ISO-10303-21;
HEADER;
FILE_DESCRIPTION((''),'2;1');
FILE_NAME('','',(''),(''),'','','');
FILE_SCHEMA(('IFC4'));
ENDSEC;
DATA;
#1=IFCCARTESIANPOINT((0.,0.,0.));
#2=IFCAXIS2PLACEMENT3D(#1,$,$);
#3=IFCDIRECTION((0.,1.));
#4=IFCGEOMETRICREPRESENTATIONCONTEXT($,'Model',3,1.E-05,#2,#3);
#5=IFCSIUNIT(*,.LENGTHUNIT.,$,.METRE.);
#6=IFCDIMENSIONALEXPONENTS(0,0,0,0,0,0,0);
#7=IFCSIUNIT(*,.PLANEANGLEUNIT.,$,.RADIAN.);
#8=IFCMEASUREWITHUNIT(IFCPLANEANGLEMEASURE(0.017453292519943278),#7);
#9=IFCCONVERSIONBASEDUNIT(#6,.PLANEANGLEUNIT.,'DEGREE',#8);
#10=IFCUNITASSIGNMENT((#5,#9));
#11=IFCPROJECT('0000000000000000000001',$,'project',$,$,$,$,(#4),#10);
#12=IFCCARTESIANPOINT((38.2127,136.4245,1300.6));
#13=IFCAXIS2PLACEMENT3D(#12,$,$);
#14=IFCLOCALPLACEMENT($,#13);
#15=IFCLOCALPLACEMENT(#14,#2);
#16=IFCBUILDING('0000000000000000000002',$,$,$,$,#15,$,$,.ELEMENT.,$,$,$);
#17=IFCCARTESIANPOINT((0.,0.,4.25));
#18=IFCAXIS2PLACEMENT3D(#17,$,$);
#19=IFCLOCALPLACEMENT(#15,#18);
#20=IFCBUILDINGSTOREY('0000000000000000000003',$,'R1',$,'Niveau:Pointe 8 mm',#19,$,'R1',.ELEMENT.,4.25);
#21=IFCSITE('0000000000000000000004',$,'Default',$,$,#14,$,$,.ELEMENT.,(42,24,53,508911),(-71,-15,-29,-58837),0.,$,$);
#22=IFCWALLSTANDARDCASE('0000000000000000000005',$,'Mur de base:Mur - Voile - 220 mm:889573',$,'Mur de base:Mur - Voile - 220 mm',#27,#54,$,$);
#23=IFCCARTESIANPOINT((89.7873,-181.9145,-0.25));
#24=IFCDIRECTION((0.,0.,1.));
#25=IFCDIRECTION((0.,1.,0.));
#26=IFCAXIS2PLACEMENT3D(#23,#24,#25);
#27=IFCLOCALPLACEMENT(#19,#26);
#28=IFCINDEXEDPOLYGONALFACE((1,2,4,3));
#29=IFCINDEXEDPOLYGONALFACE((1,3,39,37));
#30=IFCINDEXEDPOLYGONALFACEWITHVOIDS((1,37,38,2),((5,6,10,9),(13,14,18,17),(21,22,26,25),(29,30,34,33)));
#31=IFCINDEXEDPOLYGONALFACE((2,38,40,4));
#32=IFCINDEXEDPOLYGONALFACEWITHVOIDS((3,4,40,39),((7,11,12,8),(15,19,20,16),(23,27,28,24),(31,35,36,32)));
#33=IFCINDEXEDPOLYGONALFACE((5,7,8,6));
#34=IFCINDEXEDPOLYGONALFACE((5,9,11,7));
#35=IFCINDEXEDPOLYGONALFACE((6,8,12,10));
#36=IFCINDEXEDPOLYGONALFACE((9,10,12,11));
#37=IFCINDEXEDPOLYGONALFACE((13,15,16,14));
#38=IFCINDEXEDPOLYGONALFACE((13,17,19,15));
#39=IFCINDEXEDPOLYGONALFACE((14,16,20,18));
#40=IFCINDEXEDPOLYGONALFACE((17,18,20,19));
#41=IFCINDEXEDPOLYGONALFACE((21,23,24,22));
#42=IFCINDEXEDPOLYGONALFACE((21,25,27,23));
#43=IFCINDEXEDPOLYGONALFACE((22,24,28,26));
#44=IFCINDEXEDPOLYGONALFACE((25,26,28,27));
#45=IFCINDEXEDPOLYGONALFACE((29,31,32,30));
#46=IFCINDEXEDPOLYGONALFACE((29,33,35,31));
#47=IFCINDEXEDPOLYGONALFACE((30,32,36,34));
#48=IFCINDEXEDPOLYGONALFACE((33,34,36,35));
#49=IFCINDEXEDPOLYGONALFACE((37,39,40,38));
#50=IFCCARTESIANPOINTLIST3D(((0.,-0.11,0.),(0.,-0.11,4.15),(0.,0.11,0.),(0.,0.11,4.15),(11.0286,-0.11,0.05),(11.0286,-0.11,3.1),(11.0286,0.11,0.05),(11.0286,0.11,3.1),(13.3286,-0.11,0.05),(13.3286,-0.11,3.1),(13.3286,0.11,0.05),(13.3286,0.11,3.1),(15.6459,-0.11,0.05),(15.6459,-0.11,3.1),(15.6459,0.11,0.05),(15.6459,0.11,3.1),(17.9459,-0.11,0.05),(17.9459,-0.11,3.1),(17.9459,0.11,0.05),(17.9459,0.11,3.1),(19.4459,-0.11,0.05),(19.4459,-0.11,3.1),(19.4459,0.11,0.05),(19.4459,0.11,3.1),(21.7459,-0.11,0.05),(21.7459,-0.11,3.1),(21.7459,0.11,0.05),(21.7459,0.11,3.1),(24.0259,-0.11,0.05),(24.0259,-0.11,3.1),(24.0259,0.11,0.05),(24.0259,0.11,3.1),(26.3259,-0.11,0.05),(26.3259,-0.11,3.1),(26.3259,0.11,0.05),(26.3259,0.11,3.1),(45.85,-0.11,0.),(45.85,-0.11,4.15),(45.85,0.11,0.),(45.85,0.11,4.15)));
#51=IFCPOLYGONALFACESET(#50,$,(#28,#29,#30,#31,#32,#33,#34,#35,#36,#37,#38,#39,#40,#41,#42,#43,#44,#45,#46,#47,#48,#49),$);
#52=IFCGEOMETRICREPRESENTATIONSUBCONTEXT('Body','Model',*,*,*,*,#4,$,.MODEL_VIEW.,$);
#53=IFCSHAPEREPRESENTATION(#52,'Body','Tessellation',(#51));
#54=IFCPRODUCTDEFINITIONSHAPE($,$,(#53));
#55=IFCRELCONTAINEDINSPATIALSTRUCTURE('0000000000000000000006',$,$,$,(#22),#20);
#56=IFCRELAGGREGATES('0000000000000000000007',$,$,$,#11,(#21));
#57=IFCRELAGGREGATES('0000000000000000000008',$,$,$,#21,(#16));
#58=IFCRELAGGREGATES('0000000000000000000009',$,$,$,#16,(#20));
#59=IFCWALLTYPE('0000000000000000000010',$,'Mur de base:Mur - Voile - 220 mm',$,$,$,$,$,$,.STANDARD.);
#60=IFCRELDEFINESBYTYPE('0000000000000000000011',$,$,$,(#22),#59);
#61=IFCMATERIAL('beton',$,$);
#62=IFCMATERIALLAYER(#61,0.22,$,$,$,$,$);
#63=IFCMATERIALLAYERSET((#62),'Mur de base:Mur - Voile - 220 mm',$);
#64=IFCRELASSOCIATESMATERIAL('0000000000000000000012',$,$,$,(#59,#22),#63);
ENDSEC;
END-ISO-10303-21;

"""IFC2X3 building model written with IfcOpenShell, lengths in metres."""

from ifc_helpers import new_model, entity, si_unit, converted_unit, direction, frame, frame_2d, origin, place, context, subcontext, project, spatial, polyline, rectangle, extrude, clip, bounded_halfspace, material, layer, layer_set, layer_usage, type_object, element, save


model = new_model("IFC2X3")

# Units and contexts
model_context = context("Model", 3, precision=1e-05, world=origin(), true_north=direction((0.0, 1.0)))
body_context = subcontext(model_context, "Body", "Model", "MODEL_VIEW")
ifc_project = project(units=[si_unit("LENGTHUNIT", "METRE"), converted_unit("PLANEANGLEUNIT", "DEGREE", entity("IfcPlaneAngleMeasure", 0.017453292519943278), si_unit("PLANEANGLEUNIT", "RADIAN"), dimensions=[0, 0, 0, 0, 0, 0, 0])], contexts=[model_context])

# Site, building, storey
site_placement = place(None, frame((38.2127, 136.4245, 1300.6)))
site = spatial("IfcSite", under=ifc_project, at=site_placement, Name="Default", CompositionType="ELEMENT", RefLatitude=(42, 24, 53, 508911), RefLongitude=(-71, -15, -29, -58837), RefElevation=0.0)
building_placement = place(site_placement, origin())
building = spatial("IfcBuilding", under=site, at=building_placement, CompositionType="ELEMENT")
storey_placement = place(building_placement, frame((0.0, 0.0, 4.25)))
storey = spatial("IfcBuildingStorey", under=building, at=storey_placement, Name="R1", ObjectType="Niveau:Pointe 8 mm", LongName="R1", CompositionType="ELEMENT", Elevation=4.25)

# Wall, openings
ifc_material = material(Name="beton")
ifc_layer = layer(ifc_material, 0.22)
ifc_layer_set = layer_set([ifc_layer], Name="Mur de base:Mur - Voile - 220 mm")
ifc_layer_usage_1 = layer_usage(ifc_layer_set, "AXIS2", "NEGATIVE", 0.11)
wall_type = type_object("IfcWallType", Name="Mur de base:Mur - Voile - 220 mm", PredefinedType="STANDARD", material=ifc_layer_set)
wall_1_placement = place(storey_placement, frame((89.7873, -181.9145, -0.25), z_axis=(0.0, 0.0, 1.0), x_axis=(0.0, 1.0, 0.0)))
wall_1 = element("IfcWallStandardCase", 1, at=wall_1_placement, inside=storey, type_object=wall_type, material=ifc_layer_usage_1, Name="Mur de base:Mur - Voile - 220 mm:889573", ObjectType="Mur de base:Mur - Voile - 220 mm", context=body_context, shape_type="Clipping", body=[
    clip(clip(extrude(rectangle(XDim=45.85, YDim=0.22, at=frame_2d((22.925, 0.0), x_axis=(-1.0, 0.0))), origin(), (0.0, 0.0, 1.0), 4.15), bounded_halfspace(frame((35.415, -0.11, 4.15), z_axis=(0.0, 0.0, -1.0), x_axis=(0.0, -1.0, 0.0)), True, frame((35.415, -0.11, 4.15)), polyline([(0.0, 0.0), (10.185, 0.0), (10.185, 0.22), (4.42, 0.22), (4.2, 0.22), (0.22, 0.22), (0.0, 0.22), (0.0, 0.0)]))), bounded_halfspace(frame((0.25, -0.11, 4.15), z_axis=(0.0, 0.0, -1.0), x_axis=(0.0, -1.0, 0.0)), True, frame((0.25, -0.11, 4.15)), polyline([(0.0, 0.0), (32.765, 0.0), (32.765, 0.22), (32.545, 0.22), (31.185, 0.22), (30.965, 0.22), (27.12, 0.22), (26.9, 0.22), (8.8891, 0.22), (8.6691, 0.22), (0.0, 0.22), (0.0, 0.0)]))),
])
opening_1_placement = place(wall_1_placement, origin())
element("IfcOpeningElement", 2, at=opening_1_placement, cuts=wall_1, ObjectType="Opening", context=body_context, shape_type="SweptSolid", body=[
    extrude(rectangle(XDim=3.05, YDim=2.3, at=frame_2d((0.0, 0.0), x_axis=(0.0, 1.0))), frame((12.1786, 0.11, 1.575), z_axis=(0.0, -1.0, 0.0), x_axis=(-1.0, 0.0, 0.0)), (0.0, 0.0, 1.0), 0.22),
])
opening_2_placement = place(wall_1_placement, origin())
element("IfcOpeningElement", 3, at=opening_2_placement, cuts=wall_1, ObjectType="Opening", context=body_context, shape_type="SweptSolid", body=[
    extrude(rectangle(XDim=3.05, YDim=2.3, at=frame_2d((0.0, 0.0), x_axis=(0.0, 1.0))), frame((16.7959, 0.11, 1.575), z_axis=(0.0, -1.0, 0.0), x_axis=(-1.0, 0.0, 0.0)), (0.0, 0.0, 1.0), 0.22),
])
opening_3_placement = place(wall_1_placement, origin())
element("IfcOpeningElement", 4, at=opening_3_placement, cuts=wall_1, ObjectType="Opening", context=body_context, shape_type="SweptSolid", body=[
    extrude(rectangle(XDim=3.05, YDim=2.3, at=frame_2d((0.0, 0.0), x_axis=(0.0, 1.0))), frame((20.5959, 0.11, 1.575), z_axis=(0.0, -1.0, 0.0), x_axis=(-1.0, 0.0, 0.0)), (0.0, 0.0, 1.0), 0.22),
])
opening_4_placement = place(wall_1_placement, origin())
element("IfcOpeningElement", 5, at=opening_4_placement, cuts=wall_1, ObjectType="Opening", context=body_context, shape_type="SweptSolid", body=[
    extrude(rectangle(XDim=3.05, YDim=2.3, at=frame_2d((0.0, 0.0), x_axis=(0.0, 1.0))), frame((25.1759, 0.11, 1.575), z_axis=(0.0, -1.0, 0.0), x_axis=(-1.0, 0.0, 0.0)), (0.0, 0.0, 1.0), 0.22),
])

save(model, "model.ifc")
